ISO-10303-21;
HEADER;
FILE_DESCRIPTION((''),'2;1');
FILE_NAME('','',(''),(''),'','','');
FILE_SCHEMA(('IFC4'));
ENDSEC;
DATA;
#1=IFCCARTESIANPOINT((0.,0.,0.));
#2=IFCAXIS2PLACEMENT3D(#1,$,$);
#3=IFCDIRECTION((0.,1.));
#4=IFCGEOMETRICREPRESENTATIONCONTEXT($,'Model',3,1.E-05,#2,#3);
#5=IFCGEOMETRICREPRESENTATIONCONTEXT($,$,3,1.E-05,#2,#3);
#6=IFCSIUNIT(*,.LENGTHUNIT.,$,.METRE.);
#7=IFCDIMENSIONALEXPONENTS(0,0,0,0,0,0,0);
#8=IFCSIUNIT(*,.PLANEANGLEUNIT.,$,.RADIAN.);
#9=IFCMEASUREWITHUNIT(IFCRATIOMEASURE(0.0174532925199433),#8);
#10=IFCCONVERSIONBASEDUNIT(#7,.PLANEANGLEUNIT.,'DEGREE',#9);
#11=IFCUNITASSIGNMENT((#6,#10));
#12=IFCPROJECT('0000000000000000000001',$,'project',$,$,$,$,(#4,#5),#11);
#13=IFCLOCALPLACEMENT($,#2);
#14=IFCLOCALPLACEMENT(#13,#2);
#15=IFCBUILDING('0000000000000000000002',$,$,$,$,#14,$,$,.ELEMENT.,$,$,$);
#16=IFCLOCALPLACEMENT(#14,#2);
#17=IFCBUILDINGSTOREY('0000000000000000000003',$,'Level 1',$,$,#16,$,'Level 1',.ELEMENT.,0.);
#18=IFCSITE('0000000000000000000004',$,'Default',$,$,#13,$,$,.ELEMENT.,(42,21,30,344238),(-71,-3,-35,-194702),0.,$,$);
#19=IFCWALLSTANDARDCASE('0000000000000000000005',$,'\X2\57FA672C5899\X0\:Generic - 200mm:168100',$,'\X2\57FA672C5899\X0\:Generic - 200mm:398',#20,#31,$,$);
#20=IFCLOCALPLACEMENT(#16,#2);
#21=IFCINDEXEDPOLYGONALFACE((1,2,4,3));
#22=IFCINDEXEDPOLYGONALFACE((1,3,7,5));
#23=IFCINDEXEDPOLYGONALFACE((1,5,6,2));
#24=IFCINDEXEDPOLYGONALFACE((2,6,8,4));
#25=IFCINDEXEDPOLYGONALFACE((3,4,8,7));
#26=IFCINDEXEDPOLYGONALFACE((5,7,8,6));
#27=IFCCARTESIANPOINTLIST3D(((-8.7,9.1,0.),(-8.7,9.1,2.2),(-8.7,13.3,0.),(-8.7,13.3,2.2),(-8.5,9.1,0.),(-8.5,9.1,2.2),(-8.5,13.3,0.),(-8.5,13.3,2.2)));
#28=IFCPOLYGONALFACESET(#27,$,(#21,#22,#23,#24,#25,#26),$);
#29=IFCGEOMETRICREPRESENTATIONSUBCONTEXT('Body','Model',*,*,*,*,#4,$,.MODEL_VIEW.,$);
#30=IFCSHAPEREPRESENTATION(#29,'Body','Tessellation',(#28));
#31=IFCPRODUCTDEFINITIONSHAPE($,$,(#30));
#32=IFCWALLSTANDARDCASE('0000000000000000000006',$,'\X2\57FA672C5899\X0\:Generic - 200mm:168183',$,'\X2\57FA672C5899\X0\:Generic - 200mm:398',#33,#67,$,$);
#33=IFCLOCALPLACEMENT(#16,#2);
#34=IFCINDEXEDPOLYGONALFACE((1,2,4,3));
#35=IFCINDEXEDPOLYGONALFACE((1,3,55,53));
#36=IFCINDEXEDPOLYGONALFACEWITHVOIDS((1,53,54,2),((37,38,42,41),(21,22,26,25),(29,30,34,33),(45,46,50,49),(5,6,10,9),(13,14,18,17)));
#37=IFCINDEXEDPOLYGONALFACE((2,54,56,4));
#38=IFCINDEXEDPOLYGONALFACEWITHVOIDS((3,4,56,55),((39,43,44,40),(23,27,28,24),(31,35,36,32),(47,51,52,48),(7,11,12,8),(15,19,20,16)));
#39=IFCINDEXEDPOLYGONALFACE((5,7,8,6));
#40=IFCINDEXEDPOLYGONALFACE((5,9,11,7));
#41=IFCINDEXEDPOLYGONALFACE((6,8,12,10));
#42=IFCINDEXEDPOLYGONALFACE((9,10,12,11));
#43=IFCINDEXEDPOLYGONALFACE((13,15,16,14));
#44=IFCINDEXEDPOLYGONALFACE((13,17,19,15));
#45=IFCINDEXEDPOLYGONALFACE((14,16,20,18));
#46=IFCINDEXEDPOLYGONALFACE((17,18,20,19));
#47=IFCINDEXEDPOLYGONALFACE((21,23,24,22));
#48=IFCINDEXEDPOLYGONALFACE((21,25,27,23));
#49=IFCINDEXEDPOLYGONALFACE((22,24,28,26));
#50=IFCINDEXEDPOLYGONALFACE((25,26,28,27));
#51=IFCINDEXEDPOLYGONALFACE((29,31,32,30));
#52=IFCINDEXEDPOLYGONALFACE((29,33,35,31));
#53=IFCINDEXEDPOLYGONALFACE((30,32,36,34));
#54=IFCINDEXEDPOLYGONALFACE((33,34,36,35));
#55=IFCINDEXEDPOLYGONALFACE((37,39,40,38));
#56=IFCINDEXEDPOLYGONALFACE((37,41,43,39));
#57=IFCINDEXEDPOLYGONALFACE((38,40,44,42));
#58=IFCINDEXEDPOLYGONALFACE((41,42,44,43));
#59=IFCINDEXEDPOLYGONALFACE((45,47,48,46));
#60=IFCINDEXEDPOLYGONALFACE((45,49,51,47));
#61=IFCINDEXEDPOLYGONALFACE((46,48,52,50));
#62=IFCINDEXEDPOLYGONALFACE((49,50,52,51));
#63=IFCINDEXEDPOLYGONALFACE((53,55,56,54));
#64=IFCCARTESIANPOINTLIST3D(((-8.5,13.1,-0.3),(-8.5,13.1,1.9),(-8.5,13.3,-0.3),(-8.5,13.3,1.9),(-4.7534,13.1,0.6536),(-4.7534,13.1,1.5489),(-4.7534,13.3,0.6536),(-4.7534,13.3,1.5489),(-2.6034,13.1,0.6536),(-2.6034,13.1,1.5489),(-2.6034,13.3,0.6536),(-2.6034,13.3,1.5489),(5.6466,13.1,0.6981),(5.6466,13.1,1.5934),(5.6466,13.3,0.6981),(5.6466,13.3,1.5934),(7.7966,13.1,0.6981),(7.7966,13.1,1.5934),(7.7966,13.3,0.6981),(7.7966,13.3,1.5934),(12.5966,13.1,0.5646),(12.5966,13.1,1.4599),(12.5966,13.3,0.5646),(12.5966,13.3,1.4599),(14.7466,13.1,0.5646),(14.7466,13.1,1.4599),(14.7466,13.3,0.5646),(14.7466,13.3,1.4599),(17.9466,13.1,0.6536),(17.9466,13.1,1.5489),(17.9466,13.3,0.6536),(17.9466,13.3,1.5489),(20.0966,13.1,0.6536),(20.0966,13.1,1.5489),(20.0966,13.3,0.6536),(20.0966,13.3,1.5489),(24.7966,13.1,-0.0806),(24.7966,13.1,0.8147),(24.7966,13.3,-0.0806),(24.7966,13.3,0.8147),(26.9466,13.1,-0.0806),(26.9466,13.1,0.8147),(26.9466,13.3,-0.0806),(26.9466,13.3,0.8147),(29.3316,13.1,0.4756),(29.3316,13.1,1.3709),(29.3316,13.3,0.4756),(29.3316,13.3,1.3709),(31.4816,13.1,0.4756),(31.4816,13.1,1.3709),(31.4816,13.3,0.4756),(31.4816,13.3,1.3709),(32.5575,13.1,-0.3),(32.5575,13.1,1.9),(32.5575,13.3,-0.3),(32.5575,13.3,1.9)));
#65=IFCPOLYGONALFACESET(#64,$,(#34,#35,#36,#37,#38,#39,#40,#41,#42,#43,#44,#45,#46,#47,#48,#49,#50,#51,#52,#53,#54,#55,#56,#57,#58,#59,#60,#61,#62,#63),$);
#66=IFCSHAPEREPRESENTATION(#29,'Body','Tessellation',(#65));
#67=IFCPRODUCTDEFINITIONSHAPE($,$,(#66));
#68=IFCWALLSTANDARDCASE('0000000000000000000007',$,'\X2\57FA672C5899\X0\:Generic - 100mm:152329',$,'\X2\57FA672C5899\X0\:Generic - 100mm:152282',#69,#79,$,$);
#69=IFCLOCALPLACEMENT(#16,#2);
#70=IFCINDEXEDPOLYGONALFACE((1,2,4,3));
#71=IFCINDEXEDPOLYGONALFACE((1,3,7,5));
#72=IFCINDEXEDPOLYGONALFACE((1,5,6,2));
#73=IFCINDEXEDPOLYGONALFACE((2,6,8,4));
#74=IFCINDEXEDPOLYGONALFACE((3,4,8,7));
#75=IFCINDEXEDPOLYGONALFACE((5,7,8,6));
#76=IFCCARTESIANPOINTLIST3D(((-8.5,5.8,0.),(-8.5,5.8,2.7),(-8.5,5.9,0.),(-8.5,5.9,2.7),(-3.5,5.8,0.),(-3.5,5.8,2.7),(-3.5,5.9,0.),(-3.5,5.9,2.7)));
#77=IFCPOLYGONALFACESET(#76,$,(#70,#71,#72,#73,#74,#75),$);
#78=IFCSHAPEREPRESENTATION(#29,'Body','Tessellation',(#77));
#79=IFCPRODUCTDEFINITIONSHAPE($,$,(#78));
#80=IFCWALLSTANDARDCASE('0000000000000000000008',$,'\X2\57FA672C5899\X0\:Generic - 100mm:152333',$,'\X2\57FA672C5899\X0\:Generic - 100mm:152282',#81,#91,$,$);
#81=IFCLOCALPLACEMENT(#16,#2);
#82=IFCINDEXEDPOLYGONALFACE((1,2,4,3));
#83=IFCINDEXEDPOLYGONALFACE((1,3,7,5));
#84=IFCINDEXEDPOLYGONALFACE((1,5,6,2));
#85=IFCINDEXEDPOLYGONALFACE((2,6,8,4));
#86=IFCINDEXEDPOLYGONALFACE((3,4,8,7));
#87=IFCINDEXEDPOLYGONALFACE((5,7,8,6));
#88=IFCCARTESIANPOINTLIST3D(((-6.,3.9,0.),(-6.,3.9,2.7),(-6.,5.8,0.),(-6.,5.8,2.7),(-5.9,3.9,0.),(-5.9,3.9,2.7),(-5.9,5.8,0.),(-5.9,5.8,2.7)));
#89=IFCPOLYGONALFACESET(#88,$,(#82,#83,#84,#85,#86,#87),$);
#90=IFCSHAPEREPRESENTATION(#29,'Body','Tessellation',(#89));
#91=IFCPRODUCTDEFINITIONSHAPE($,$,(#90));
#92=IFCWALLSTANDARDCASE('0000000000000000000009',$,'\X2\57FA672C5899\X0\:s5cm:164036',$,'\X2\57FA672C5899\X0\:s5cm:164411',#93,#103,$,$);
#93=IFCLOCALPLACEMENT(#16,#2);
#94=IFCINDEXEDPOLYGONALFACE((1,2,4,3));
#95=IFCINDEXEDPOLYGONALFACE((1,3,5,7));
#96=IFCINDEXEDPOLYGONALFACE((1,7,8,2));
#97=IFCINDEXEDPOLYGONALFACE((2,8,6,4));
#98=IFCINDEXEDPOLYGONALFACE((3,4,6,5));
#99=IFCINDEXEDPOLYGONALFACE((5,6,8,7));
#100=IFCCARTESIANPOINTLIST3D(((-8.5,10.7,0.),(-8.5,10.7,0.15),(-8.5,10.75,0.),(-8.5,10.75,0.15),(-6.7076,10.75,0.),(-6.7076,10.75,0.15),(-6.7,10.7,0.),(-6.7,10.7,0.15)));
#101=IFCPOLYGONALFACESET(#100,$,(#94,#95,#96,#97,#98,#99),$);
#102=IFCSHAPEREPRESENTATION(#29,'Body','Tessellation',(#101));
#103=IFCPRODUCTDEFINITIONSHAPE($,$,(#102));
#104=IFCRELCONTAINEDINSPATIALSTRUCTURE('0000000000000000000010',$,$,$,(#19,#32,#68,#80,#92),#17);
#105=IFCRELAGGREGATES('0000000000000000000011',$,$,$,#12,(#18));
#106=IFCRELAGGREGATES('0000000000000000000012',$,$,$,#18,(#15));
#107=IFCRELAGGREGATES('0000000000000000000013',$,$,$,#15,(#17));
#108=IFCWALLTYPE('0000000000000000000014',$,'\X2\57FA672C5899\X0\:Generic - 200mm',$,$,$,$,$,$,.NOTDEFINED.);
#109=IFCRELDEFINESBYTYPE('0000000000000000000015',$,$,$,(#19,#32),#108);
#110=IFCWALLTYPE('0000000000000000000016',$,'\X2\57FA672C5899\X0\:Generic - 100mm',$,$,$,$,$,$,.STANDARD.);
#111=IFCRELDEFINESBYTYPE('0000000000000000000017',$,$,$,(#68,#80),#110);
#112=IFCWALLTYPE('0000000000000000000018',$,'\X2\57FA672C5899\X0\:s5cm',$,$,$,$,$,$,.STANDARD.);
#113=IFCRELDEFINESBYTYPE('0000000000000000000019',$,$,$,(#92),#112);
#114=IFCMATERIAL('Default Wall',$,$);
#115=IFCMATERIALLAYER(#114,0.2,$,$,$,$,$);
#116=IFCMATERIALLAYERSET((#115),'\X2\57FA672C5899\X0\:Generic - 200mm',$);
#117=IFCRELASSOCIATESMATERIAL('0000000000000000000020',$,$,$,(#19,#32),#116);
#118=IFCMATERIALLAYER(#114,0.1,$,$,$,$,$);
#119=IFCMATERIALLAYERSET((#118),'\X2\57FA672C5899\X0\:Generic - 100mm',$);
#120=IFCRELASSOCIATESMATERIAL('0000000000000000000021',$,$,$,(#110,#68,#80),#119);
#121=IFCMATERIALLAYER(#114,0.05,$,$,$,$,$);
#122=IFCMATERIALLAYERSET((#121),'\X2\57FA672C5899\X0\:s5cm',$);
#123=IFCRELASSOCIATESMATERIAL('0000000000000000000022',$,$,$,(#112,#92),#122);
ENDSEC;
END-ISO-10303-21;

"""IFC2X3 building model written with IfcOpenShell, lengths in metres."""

from ifc_helpers import new_model, entity, si_unit, converted_unit, direction, frame, frame_2d, origin, place, context, subcontext, project, spatial, polyline, rectangle, outline, extrude, clip, bounded_halfspace, material, layer, layer_set, layer_usage, type_object, element, save


model = new_model("IFC2X3")

# Units and contexts
model_context = context("Model", 3, precision=1e-05, world=origin(), true_north=direction((0.0, 1.0)))
context_of_model = context(None, 3, precision=1e-05, world=origin(), true_north=direction((0.0, 1.0)))
body_context = subcontext(model_context, "Body", "Model", "MODEL_VIEW")
ifc_project = project(units=[si_unit("LENGTHUNIT", "METRE"), converted_unit("PLANEANGLEUNIT", "DEGREE", entity("IfcRatioMeasure", 0.0174532925199433), si_unit("PLANEANGLEUNIT", "RADIAN"), dimensions=[0, 0, 0, 0, 0, 0, 0])], contexts=[model_context, context_of_model])

# Site, building, storey
site_placement = place(None, origin())
site = spatial("IfcSite", under=ifc_project, at=site_placement, Name="Default", CompositionType="ELEMENT", RefLatitude=(42, 21, 30, 344238), RefLongitude=(-71, -3, -35, -194702), RefElevation=0.0)
building_placement = place(site_placement, origin())
building = spatial("IfcBuilding", under=site, at=building_placement, CompositionType="ELEMENT")
storey_placement = place(building_placement, origin())
storey = spatial("IfcBuildingStorey", under=building, at=storey_placement, Name="Level 1", LongName="Level 1", CompositionType="ELEMENT", Elevation=0.0)

# Wall
ifc_material_1 = material(Name="Default Wall")
ifc_layer_1 = layer(ifc_material_1, 0.2)
ifc_layer_set_1 = layer_set([ifc_layer_1], Name="基本墙:Generic - 200mm")
ifc_layer_usage_1 = layer_usage(ifc_layer_set_1, "AXIS2", "NEGATIVE", 0.1)
wall_type_1 = type_object("IfcWallType", Name="基本墙:Generic - 200mm", PredefinedType="NOTDEFINED")
wall_1_placement = place(storey_placement, frame((-8.6, 9.1, 0.0), z_axis=(0.0, 0.0, 1.0), x_axis=(0.0, 1.0, 0.0)))
element("IfcWallStandardCase", 1, at=wall_1_placement, inside=storey, type_object=wall_type_1, material=ifc_layer_usage_1, Name="基本墙:Generic - 200mm:168100", ObjectType="基本墙:Generic - 200mm:398", context=body_context, shape_type="SweptSolid", body=[
    extrude(rectangle(XDim=4.2, YDim=0.2, at=frame_2d((2.1, 0.0), x_axis=(-1.0, 0.0))), origin(), (0.0, 0.0, 1.0), 2.2),
])

# Wall, openings
ifc_layer_usage_2 = layer_usage(ifc_layer_set_1, "AXIS2", "NEGATIVE", 0.1)
wall_2_placement = place(storey_placement, frame((-8.5, 13.2, -0.3)))
wall_2 = element("IfcWallStandardCase", 2, at=wall_2_placement, inside=storey, type_object=wall_type_1, material=ifc_layer_usage_2, Name="基本墙:Generic - 200mm:168183", ObjectType="基本墙:Generic - 200mm:398", context=body_context, shape_type="SweptSolid", body=[
    extrude(rectangle(XDim=41.0575, YDim=0.2, at=frame_2d((20.5287, 0.0), x_axis=(-1.0, 0.0))), origin(), (0.0, 0.0, 1.0), 2.2),
])
opening_1_placement = place(wall_2_placement, frame((37.8316, -0.2048, 0.7756)))
element("IfcOpeningElement", 3, at=opening_1_placement, cuts=wall_2, ObjectType="Opening", context=body_context, shape_type="SweptSolid", body=[
    extrude(rectangle(XDim=0.8953, YDim=2.15, at=frame_2d((0.0, 0.0), x_axis=(0.0, 1.0))), frame((1.075, 0.0, 0.4477), z_axis=(0.0, 1.0, 0.0), x_axis=(1.0, 0.0, 0.0)), (0.0, 0.0, 1.0), 0.3048),
])
opening_2_placement = place(wall_2_placement, frame((33.2966, -0.2048, 0.2194)))
element("IfcOpeningElement", 4, at=opening_2_placement, cuts=wall_2, ObjectType="Opening", context=body_context, shape_type="SweptSolid", body=[
    extrude(rectangle(XDim=0.8953, YDim=2.15, at=frame_2d((0.0, 0.0), x_axis=(0.0, 1.0))), frame((1.075, 0.0, 0.4477), z_axis=(0.0, 1.0, 0.0), x_axis=(1.0, 0.0, 0.0)), (0.0, 0.0, 1.0), 0.3048),
])
opening_3_placement = place(wall_2_placement, frame((26.4466, -0.2048, 0.9536)))
element("IfcOpeningElement", 5, at=opening_3_placement, cuts=wall_2, ObjectType="Opening", context=body_context, shape_type="SweptSolid", body=[
    extrude(rectangle(XDim=0.8953, YDim=2.15, at=frame_2d((0.0, 0.0), x_axis=(0.0, 1.0))), frame((1.075, 0.0, 0.4477), z_axis=(0.0, 1.0, 0.0), x_axis=(1.0, 0.0, 0.0)), (0.0, 0.0, 1.0), 0.3048),
])
opening_4_placement = place(wall_2_placement, frame((21.0966, -0.2048, 0.8646)))
element("IfcOpeningElement", 6, at=opening_4_placement, cuts=wall_2, ObjectType="Opening", context=body_context, shape_type="SweptSolid", body=[
    extrude(rectangle(XDim=0.8953, YDim=2.15, at=frame_2d((0.0, 0.0), x_axis=(0.0, 1.0))), frame((1.075, 0.0, 0.4477), z_axis=(0.0, 1.0, 0.0), x_axis=(1.0, 0.0, 0.0)), (0.0, 0.0, 1.0), 0.3048),
])
opening_5_placement = place(wall_2_placement, frame((14.1466, -0.2048, 0.9981)))
element("IfcOpeningElement", 7, at=opening_5_placement, cuts=wall_2, ObjectType="Opening", context=body_context, shape_type="SweptSolid", body=[
    extrude(rectangle(XDim=0.8953, YDim=2.15, at=frame_2d((0.0, 0.0), x_axis=(0.0, 1.0))), frame((1.075, 0.0, 0.4477), z_axis=(0.0, 1.0, 0.0), x_axis=(1.0, 0.0, 0.0)), (0.0, 0.0, 1.0), 0.3048),
])
opening_6_placement = place(wall_2_placement, frame((3.7466, -0.2048, 0.9536)))
element("IfcOpeningElement", 8, at=opening_6_placement, cuts=wall_2, ObjectType="Opening", context=body_context, shape_type="SweptSolid", body=[
    extrude(rectangle(XDim=0.8953, YDim=2.15, at=frame_2d((0.0, 0.0), x_axis=(0.0, 1.0))), frame((1.075, 0.0, 0.4477), z_axis=(0.0, 1.0, 0.0), x_axis=(1.0, 0.0, 0.0)), (0.0, 0.0, 1.0), 0.3048),
])

# Walls
ifc_layer_2 = layer(ifc_material_1, 0.1)
ifc_layer_set_2 = layer_set([ifc_layer_2], Name="基本墙:Generic - 100mm")
ifc_layer_usage_3 = layer_usage(ifc_layer_set_2, "AXIS2", "NEGATIVE", 0.05)
wall_type_2 = type_object("IfcWallType", Name="基本墙:Generic - 100mm", PredefinedType="STANDARD", material=ifc_layer_set_2)
wall_3_placement = place(storey_placement, frame((-8.5, 5.85, 0.0)))
element("IfcWallStandardCase", 9, at=wall_3_placement, inside=storey, type_object=wall_type_2, material=ifc_layer_usage_3, Name="基本墙:Generic - 100mm:152329", ObjectType="基本墙:Generic - 100mm:152282", context=body_context, shape_type="Clipping", body=[
    clip(extrude(rectangle(XDim=5.0, YDim=0.1, at=frame_2d((2.5, 0.0), x_axis=(-1.0, 0.0))), origin(), (0.0, 0.0, 1.0), 3.0), bounded_halfspace(frame((0.0, -0.05, 2.7), z_axis=(0.0, 0.0, -1.0), x_axis=(0.0, -1.0, 0.0)), True, frame((0.0, -0.05, 2.7), z_axis=(0.0, 0.0, -1.0), x_axis=(0.0, -1.0, 0.0)), polyline([(0.0, 0.0), (-0.1, 0.0), (-0.1, -5.0), (0.0, -5.0), (0.0, -2.6), (0.0, -2.5), (0.0, 0.0)]))),
])
ifc_layer_usage_4 = layer_usage(ifc_layer_set_2, "AXIS2", "NEGATIVE", 0.05)
wall_4_placement = place(storey_placement, frame((-5.95, 5.8, 0.0), z_axis=(0.0, 0.0, 1.0), x_axis=(0.0, -1.0, 0.0)))
element("IfcWallStandardCase", 10, at=wall_4_placement, inside=storey, type_object=wall_type_2, material=ifc_layer_usage_4, Name="基本墙:Generic - 100mm:152333", ObjectType="基本墙:Generic - 100mm:152282", context=body_context, shape_type="Clipping", body=[
    clip(extrude(rectangle(XDim=1.9, YDim=0.1, at=frame_2d((0.95, 0.0), x_axis=(-1.0, 0.0))), origin(), (0.0, 0.0, 1.0), 3.0), bounded_halfspace(frame((0.0, -0.05, 2.7), z_axis=(0.0, 0.0, -1.0), x_axis=(1.0, 0.0, 0.0)), True, frame((0.0, -0.05, 2.7), z_axis=(0.0, 0.0, -1.0), x_axis=(1.0, 0.0, 0.0)), polyline([(0.0, 0.0), (0.0, -0.1), (1.9, -0.1), (1.9, 0.0), (0.0, 0.0)]))),
])
ifc_layer_3 = layer(ifc_material_1, 0.05)
ifc_layer_set_3 = layer_set([ifc_layer_3], Name="基本墙:s5cm")
ifc_layer_usage_5 = layer_usage(ifc_layer_set_3, "AXIS2", "NEGATIVE", 0.025)
wall_type_3 = type_object("IfcWallType", Name="基本墙:s5cm", PredefinedType="STANDARD", material=ifc_layer_set_3)
wall_5_placement = place(storey_placement, frame((-6.7, 10.725, 0.0), z_axis=(0.0, 0.0, 1.0), x_axis=(-1.0, 0.0, 0.0)))
element("IfcWallStandardCase", 11, at=wall_5_placement, inside=storey, type_object=wall_type_3, material=ifc_layer_usage_5, Name="基本墙:s5cm:164036", ObjectType="基本墙:s5cm:164411", context=body_context, shape_type="SweptSolid", body=[
    extrude(outline(polyline([(1.8, -0.025), (1.8, 0.025), (0.0, 0.025), (0.0076, -0.025), (1.8, -0.025)])), origin(), (0.0, 0.0, 1.0), 0.15),
])

save(model, "model.ifc")
